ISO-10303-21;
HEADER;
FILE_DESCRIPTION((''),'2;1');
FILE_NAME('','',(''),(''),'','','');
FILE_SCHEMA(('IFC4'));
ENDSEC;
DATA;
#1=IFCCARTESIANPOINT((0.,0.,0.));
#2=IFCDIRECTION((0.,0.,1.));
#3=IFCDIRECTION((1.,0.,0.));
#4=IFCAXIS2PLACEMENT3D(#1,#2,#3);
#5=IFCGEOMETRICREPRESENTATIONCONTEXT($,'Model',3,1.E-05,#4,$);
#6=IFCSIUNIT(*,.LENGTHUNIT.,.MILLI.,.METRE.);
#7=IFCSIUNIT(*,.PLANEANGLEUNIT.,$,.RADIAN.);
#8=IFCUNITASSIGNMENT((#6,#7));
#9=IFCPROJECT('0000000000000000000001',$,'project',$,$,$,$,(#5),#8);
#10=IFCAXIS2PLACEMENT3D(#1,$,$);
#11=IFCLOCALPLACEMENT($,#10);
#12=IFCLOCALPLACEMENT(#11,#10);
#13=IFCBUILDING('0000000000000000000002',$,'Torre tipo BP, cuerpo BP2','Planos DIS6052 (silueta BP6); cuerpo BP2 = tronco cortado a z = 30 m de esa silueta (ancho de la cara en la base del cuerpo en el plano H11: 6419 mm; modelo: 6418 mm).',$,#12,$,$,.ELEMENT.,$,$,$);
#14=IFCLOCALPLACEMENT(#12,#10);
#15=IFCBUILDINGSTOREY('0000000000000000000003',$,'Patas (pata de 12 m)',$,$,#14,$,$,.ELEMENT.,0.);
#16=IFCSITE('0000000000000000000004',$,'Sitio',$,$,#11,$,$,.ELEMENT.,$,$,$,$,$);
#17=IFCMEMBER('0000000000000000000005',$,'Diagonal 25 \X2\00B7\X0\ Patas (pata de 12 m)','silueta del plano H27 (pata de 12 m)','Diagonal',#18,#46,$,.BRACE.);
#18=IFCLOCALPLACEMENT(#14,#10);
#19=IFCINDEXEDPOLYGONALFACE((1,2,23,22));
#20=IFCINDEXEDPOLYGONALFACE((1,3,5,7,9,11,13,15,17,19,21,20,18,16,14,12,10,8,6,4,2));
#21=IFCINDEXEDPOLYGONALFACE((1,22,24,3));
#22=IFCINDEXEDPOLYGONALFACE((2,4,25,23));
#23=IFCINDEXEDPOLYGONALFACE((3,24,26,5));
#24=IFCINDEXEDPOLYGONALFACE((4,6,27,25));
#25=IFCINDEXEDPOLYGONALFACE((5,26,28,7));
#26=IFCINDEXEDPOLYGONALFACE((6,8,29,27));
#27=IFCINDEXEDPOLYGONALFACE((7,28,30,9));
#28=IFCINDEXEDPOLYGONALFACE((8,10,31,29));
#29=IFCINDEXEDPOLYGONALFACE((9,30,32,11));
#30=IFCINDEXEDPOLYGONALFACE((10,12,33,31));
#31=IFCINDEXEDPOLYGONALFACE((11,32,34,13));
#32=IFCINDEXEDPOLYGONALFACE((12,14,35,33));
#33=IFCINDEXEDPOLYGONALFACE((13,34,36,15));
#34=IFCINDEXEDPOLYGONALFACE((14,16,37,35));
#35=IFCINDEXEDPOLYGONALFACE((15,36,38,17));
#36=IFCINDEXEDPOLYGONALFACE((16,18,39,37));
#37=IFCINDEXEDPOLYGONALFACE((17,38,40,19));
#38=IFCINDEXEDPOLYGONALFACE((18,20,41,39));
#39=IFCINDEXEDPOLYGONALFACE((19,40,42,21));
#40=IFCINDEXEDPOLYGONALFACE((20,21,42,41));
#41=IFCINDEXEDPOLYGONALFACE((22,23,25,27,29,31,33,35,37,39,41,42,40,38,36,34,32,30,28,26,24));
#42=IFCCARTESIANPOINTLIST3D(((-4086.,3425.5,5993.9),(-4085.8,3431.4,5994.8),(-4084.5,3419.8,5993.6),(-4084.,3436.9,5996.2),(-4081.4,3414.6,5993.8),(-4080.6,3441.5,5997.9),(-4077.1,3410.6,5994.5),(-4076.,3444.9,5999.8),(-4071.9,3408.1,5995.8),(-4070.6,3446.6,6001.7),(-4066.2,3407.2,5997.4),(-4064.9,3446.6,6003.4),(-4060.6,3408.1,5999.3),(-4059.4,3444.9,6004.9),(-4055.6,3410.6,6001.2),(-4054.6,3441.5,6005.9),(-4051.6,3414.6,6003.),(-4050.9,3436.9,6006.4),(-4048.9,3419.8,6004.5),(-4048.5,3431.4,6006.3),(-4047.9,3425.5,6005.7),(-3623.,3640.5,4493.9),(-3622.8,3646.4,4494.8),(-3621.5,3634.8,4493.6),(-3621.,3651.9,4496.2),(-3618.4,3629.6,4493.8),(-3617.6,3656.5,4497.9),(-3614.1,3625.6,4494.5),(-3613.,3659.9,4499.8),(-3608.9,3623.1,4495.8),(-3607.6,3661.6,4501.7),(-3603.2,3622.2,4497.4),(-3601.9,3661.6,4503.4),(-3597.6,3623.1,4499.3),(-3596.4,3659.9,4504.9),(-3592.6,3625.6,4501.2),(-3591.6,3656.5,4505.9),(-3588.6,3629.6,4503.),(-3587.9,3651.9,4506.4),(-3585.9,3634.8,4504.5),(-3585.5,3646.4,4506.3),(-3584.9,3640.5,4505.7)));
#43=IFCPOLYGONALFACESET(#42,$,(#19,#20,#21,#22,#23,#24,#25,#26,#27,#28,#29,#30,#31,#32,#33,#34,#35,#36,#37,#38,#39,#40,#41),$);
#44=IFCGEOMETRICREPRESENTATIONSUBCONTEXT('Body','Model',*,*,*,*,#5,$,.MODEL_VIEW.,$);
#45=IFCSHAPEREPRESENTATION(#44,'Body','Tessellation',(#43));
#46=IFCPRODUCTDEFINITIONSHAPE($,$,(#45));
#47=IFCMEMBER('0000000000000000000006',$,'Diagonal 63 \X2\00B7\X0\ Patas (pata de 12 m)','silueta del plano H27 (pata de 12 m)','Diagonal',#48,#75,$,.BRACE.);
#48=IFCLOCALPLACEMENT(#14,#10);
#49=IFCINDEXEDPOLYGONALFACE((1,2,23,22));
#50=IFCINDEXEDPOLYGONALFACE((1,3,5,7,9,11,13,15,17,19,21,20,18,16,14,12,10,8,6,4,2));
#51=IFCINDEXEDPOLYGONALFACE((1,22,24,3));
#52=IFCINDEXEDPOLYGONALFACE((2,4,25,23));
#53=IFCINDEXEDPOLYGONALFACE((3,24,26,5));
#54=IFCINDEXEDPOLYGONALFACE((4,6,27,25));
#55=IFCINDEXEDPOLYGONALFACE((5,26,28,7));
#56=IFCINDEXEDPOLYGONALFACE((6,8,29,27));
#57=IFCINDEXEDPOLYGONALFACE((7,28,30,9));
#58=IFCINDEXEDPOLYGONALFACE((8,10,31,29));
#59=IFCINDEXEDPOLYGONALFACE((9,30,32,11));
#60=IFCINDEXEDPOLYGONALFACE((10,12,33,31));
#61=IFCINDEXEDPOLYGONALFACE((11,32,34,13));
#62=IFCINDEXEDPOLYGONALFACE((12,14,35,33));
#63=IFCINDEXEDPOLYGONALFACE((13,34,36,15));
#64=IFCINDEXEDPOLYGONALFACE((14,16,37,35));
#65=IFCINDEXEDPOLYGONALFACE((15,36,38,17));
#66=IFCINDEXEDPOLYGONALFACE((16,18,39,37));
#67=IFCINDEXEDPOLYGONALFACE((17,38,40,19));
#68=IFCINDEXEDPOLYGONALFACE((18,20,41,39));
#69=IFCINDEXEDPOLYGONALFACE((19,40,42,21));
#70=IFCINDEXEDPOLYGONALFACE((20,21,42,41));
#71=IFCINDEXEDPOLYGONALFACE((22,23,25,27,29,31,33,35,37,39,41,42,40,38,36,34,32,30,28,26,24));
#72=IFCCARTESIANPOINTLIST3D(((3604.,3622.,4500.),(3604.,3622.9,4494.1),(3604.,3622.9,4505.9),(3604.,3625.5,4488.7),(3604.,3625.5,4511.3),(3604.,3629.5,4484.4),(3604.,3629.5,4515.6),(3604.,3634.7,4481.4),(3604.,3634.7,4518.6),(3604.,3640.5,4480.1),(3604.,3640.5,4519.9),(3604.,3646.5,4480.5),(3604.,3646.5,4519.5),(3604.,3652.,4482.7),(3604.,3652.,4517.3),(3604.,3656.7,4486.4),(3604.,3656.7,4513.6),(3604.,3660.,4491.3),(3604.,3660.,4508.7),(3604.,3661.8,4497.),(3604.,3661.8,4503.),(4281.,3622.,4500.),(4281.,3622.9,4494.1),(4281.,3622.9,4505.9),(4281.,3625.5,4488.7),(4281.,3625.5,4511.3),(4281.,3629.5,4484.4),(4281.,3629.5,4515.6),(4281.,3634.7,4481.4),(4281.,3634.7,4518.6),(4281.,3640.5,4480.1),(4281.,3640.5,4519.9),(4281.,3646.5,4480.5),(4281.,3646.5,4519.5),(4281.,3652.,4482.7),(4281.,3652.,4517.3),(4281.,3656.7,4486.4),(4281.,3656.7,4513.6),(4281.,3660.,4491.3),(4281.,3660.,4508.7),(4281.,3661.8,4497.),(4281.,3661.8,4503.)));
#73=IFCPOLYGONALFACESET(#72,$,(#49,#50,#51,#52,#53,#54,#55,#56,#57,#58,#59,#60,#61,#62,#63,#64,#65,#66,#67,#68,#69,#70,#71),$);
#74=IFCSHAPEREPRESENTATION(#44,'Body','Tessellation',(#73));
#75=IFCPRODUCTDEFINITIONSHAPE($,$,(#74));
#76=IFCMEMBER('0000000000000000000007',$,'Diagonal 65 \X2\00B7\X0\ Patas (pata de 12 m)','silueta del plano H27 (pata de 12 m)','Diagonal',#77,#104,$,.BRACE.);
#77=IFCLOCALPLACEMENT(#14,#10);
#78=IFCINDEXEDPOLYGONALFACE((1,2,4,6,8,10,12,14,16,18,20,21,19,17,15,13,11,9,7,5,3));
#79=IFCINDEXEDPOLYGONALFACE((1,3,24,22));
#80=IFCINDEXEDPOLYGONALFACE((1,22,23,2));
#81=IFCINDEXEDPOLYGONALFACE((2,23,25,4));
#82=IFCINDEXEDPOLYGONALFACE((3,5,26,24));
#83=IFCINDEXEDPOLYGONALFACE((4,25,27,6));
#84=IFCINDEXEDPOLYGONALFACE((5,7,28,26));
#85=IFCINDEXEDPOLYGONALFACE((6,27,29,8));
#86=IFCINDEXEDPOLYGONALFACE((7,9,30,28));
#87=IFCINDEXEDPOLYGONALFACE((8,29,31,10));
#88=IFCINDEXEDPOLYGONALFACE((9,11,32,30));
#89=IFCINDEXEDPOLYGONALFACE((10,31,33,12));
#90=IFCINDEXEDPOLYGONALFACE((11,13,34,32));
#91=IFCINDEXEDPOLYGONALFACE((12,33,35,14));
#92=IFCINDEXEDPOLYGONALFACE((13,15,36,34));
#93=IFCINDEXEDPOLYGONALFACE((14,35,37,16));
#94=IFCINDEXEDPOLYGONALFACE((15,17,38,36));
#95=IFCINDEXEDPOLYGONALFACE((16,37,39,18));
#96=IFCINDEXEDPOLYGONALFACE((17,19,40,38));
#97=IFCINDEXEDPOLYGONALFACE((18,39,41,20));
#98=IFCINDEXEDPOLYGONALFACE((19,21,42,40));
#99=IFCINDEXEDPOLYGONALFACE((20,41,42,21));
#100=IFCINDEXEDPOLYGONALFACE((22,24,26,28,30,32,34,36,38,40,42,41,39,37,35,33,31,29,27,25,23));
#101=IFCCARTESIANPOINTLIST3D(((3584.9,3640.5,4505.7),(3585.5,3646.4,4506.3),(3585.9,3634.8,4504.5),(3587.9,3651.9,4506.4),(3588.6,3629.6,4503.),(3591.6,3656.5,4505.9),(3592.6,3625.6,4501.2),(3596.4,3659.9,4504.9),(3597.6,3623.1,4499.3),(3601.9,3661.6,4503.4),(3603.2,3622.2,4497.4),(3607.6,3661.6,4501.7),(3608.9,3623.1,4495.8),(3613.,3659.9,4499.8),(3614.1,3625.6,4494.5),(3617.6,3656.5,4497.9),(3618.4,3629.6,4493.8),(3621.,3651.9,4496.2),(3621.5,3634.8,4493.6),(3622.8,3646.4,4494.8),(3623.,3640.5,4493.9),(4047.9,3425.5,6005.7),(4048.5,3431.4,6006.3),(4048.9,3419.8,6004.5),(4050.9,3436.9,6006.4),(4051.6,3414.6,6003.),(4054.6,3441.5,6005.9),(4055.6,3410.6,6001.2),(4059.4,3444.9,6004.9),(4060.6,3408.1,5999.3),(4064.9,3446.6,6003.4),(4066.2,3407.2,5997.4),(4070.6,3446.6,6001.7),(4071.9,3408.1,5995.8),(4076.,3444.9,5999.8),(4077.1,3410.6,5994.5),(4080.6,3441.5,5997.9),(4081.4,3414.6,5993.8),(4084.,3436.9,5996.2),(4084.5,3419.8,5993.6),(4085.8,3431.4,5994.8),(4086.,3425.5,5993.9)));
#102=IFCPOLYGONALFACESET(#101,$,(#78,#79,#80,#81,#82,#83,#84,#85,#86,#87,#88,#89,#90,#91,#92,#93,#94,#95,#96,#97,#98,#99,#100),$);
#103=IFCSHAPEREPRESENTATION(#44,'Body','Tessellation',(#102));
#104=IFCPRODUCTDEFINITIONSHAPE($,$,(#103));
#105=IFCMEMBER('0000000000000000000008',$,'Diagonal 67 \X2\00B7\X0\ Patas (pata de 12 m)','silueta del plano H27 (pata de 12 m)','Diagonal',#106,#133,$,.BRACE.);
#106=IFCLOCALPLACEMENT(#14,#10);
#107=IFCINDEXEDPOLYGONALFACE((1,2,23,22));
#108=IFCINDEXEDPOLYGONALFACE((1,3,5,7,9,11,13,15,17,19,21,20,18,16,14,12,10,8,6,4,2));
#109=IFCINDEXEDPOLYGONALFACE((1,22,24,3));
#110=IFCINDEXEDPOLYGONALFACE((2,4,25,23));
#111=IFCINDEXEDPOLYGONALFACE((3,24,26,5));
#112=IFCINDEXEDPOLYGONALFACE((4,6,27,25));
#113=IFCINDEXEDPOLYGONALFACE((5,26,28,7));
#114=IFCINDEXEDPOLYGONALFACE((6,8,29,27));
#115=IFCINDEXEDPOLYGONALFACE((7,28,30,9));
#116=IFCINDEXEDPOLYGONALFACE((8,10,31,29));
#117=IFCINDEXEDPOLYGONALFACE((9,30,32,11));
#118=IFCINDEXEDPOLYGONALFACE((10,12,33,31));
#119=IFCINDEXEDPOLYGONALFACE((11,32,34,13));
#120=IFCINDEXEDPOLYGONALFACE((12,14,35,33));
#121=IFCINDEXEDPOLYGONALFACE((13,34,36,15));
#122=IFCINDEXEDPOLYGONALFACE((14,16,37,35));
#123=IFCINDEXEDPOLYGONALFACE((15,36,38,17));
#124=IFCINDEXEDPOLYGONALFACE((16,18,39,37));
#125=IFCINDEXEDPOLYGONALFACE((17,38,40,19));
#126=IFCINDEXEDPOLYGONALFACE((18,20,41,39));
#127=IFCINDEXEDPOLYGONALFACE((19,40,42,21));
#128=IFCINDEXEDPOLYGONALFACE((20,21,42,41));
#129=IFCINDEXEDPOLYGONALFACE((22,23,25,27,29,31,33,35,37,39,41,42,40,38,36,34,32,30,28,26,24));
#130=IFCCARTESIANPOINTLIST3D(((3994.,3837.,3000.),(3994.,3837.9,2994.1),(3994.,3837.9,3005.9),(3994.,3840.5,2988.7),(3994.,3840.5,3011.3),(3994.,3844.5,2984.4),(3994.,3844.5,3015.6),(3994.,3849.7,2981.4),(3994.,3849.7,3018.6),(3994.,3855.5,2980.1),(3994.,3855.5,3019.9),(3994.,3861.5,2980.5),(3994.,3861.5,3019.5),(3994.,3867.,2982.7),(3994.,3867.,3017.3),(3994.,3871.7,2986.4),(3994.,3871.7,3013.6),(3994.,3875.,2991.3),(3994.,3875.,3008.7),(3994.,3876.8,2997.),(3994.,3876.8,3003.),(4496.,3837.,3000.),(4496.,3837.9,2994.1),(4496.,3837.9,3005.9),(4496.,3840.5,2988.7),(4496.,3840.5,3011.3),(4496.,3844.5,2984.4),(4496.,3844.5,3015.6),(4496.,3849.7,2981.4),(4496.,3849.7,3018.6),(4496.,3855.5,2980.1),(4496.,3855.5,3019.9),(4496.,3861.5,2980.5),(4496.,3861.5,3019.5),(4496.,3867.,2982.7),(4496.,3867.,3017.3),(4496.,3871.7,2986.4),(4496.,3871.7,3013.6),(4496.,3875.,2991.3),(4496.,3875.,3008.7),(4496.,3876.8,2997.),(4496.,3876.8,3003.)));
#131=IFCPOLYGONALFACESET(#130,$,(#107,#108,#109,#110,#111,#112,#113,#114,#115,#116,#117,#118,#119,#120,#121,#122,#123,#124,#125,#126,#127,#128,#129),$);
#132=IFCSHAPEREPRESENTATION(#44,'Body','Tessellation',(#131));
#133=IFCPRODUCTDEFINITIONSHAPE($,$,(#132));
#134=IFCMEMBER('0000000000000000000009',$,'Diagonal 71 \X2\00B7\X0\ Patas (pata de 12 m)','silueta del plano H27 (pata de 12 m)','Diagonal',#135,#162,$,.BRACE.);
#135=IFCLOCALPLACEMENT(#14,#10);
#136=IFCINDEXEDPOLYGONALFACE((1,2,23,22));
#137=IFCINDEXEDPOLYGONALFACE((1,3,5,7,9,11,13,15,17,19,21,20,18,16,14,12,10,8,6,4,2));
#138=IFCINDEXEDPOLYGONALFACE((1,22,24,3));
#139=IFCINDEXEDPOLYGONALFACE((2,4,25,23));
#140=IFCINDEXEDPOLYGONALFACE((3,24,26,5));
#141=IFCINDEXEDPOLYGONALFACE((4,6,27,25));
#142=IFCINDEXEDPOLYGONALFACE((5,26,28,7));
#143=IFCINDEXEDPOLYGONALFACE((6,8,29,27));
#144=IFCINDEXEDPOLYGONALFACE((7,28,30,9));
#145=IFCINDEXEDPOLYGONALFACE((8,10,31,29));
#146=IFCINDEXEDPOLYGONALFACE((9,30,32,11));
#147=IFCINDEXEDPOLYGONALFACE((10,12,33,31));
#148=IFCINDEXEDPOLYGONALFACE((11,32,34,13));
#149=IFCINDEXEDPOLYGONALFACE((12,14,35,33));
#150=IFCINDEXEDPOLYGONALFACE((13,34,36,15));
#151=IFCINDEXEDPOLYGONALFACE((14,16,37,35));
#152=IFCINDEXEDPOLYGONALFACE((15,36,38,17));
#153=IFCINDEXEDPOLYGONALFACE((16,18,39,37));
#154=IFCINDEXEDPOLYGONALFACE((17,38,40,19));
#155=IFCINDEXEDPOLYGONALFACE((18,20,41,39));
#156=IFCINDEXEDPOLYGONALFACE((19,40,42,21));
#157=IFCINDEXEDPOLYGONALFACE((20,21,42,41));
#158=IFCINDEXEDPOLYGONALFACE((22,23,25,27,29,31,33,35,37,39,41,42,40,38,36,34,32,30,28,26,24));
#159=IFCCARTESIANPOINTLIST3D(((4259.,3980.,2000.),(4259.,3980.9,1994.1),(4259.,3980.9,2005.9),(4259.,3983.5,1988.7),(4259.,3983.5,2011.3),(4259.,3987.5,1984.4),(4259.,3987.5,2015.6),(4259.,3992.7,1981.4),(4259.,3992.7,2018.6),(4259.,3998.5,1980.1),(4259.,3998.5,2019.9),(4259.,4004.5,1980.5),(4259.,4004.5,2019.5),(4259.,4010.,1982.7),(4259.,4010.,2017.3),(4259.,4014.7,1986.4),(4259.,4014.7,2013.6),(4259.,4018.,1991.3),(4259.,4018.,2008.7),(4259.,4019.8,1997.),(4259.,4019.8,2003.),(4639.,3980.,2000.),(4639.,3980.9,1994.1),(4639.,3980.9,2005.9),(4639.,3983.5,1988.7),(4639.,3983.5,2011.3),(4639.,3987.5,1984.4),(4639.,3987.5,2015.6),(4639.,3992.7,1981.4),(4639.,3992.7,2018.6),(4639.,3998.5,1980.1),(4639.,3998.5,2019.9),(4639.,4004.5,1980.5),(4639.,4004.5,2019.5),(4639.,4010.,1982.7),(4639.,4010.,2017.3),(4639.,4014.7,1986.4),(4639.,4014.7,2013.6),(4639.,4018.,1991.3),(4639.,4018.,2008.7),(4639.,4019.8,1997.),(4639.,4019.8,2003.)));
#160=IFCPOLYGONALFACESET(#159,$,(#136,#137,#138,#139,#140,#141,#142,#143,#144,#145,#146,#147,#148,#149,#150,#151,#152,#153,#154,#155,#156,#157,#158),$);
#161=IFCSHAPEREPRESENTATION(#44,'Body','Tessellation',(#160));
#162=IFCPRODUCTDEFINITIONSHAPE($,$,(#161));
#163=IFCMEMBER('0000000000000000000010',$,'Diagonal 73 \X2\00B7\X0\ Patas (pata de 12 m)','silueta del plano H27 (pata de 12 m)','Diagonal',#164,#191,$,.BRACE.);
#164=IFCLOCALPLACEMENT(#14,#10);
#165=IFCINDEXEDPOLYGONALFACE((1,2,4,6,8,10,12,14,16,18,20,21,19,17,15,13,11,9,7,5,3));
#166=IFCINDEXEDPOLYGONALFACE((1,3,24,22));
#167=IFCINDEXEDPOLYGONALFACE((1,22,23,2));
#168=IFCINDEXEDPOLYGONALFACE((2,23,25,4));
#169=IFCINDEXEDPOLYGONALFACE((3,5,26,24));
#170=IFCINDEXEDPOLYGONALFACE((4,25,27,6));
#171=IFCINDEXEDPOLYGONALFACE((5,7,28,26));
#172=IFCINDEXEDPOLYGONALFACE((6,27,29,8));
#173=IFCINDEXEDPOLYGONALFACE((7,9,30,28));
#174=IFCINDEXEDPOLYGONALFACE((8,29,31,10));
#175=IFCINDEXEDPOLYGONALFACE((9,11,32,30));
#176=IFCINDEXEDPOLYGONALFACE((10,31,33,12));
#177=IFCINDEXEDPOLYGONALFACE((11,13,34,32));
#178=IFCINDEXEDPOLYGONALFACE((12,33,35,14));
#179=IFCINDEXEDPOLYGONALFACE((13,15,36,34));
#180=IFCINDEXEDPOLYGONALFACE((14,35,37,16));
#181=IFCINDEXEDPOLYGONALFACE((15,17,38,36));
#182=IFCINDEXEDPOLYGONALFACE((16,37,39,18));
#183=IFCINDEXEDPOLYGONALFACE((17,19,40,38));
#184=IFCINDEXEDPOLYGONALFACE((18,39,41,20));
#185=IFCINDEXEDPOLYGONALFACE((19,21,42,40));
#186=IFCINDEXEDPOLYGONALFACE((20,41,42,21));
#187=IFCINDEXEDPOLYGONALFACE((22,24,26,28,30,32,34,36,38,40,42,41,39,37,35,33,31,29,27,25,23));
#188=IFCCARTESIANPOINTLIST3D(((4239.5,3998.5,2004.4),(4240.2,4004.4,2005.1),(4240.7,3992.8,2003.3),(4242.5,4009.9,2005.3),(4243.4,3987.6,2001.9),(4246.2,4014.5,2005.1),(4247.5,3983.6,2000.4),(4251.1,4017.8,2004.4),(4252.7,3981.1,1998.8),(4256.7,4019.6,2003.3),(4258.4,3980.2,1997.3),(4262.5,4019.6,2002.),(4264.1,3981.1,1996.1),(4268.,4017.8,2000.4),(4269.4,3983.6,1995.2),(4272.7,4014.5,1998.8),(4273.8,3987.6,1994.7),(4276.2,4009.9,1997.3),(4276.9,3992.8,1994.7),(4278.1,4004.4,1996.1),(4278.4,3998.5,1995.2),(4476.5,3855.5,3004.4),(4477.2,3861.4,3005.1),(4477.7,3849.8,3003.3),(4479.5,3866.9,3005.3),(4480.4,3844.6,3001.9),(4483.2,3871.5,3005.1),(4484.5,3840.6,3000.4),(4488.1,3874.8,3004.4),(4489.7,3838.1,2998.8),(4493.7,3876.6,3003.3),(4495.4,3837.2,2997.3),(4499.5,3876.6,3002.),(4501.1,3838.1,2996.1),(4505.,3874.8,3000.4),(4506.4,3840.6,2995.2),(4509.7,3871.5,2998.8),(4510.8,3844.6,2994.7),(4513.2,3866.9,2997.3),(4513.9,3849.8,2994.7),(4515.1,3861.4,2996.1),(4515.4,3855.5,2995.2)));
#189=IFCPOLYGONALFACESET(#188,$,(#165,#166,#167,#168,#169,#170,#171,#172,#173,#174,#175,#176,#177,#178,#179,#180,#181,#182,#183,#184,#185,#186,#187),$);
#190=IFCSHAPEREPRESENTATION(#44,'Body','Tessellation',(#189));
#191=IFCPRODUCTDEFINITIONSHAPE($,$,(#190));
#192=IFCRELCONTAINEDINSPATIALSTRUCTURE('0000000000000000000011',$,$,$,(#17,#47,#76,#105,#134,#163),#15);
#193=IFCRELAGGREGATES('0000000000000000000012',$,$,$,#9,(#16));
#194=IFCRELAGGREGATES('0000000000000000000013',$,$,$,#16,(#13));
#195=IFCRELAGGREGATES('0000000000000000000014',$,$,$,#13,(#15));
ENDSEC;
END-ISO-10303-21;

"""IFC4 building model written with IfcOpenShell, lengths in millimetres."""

from ifc_helpers import new_model, si_unit, frame, origin, origin_with_axes, place, context, subcontext, project, spatial, circle, extrude, element, save


model = new_model("IFC4")

# Units and contexts
model_context = context("Model", 3, precision=1e-05, world=origin_with_axes())
body_context = subcontext(model_context, "Body", "Model", "MODEL_VIEW")
ifc_project = project(units=[si_unit("LENGTHUNIT", "METRE", prefix="MILLI"), si_unit("PLANEANGLEUNIT", "RADIAN")], contexts=[model_context])

# Site, building, storey
site_placement = place(None, origin())
site = spatial("IfcSite", under=ifc_project, at=site_placement, Name="Sitio", CompositionType="ELEMENT")
building_placement = place(site_placement, origin())
building = spatial("IfcBuilding", under=site, at=building_placement, Name="Torre tipo BP, cuerpo BP2", Description="Planos DIS6052 (silueta BP6); cuerpo BP2 = tronco cortado a z = 30 m de esa silueta (ancho de la cara en la base del cuerpo en el plano H11: 6419 mm; modelo: 6418 mm).", CompositionType="ELEMENT")
storey_placement = place(building_placement, origin())
storey = spatial("IfcBuildingStorey", under=building, at=storey_placement, Name="Patas (pata de 12 m)", CompositionType="ELEMENT", Elevation=0.0)

# Members
member_1_placement = place(storey_placement, frame((-3604.0, 3642.0, 4500.0), z_axis=(-0.292208, -0.135691, 0.94668), x_axis=(0.04002, -0.990751, -0.129655)))
element("IfcMember", 1, at=member_1_placement, inside=storey, Name="Diagonal 25 · Patas (pata de 12 m)", Description="silueta del plano H27 (pata de 12 m)", ObjectType="Diagonal", PredefinedType="BRACE", context=body_context, shape_type="SweptSolid", body=[
    extrude(circle(Radius=20.0), None, (0.0, 0.0, 1.0), 1584.5),
])
member_2_placement = place(storey_placement, frame((4281.0, 3642.0, 4500.0), z_axis=(-1.0, 0.0, 0.0), x_axis=(0.0, -1.0, 0.0)))
element("IfcMember", 2, at=member_2_placement, inside=storey, Name="Diagonal 63 · Patas (pata de 12 m)", Description="silueta del plano H27 (pata de 12 m)", ObjectType="Diagonal", PredefinedType="BRACE", context=body_context, shape_type="SweptSolid", body=[
    extrude(circle(Radius=20.0), None, (0.0, 0.0, 1.0), 677.0),
])
member_3_placement = place(storey_placement, frame((3604.0, 3642.0, 4500.0), z_axis=(0.292208, -0.135691, 0.94668), x_axis=(-0.04002, -0.990751, -0.129655)))
element("IfcMember", 3, at=member_3_placement, inside=storey, Name="Diagonal 65 · Patas (pata de 12 m)", Description="silueta del plano H27 (pata de 12 m)", ObjectType="Diagonal", PredefinedType="BRACE", context=body_context, shape_type="SweptSolid", body=[
    extrude(circle(Radius=20.0), None, (0.0, 0.0, 1.0), 1584.5),
])
member_4_placement = place(storey_placement, frame((4496.0, 3857.0, 3000.0), z_axis=(-1.0, 0.0, 0.0), x_axis=(0.0, -1.0, 0.0)))
element("IfcMember", 4, at=member_4_placement, inside=storey, Name="Diagonal 67 · Patas (pata de 12 m)", Description="silueta del plano H27 (pata de 12 m)", ObjectType="Diagonal", PredefinedType="BRACE", context=body_context, shape_type="SweptSolid", body=[
    extrude(circle(Radius=20.0), None, (0.0, 0.0, 1.0), 502.0),
])
member_5_placement = place(storey_placement, frame((4639.0, 4000.0, 2000.0), z_axis=(-1.0, 0.0, 0.0), x_axis=(0.0, -1.0, 0.0)))
element("IfcMember", 5, at=member_5_placement, inside=storey, Name="Diagonal 71 · Patas (pata de 12 m)", Description="silueta del plano H27 (pata de 12 m)", ObjectType="Diagonal", PredefinedType="BRACE", context=body_context, shape_type="SweptSolid", body=[
    extrude(circle(Radius=20.0), None, (0.0, 0.0, 1.0), 380.0),
])
member_6_placement = place(storey_placement, frame((4259.0, 4000.0, 2000.0), z_axis=(0.228411, -0.137818, 0.963761), x_axis=(-0.031782, -0.990458, -0.134103)))
element("IfcMember", 6, at=member_6_placement, inside=storey, Name="Diagonal 73 · Patas (pata de 12 m)", Description="silueta del plano H27 (pata de 12 m)", ObjectType="Diagonal", PredefinedType="BRACE", context=body_context, shape_type="SweptSolid", body=[
    extrude(circle(Radius=20.0), None, (0.0, 0.0, 1.0), 1037.6),
])

save(model, "model.ifc")
